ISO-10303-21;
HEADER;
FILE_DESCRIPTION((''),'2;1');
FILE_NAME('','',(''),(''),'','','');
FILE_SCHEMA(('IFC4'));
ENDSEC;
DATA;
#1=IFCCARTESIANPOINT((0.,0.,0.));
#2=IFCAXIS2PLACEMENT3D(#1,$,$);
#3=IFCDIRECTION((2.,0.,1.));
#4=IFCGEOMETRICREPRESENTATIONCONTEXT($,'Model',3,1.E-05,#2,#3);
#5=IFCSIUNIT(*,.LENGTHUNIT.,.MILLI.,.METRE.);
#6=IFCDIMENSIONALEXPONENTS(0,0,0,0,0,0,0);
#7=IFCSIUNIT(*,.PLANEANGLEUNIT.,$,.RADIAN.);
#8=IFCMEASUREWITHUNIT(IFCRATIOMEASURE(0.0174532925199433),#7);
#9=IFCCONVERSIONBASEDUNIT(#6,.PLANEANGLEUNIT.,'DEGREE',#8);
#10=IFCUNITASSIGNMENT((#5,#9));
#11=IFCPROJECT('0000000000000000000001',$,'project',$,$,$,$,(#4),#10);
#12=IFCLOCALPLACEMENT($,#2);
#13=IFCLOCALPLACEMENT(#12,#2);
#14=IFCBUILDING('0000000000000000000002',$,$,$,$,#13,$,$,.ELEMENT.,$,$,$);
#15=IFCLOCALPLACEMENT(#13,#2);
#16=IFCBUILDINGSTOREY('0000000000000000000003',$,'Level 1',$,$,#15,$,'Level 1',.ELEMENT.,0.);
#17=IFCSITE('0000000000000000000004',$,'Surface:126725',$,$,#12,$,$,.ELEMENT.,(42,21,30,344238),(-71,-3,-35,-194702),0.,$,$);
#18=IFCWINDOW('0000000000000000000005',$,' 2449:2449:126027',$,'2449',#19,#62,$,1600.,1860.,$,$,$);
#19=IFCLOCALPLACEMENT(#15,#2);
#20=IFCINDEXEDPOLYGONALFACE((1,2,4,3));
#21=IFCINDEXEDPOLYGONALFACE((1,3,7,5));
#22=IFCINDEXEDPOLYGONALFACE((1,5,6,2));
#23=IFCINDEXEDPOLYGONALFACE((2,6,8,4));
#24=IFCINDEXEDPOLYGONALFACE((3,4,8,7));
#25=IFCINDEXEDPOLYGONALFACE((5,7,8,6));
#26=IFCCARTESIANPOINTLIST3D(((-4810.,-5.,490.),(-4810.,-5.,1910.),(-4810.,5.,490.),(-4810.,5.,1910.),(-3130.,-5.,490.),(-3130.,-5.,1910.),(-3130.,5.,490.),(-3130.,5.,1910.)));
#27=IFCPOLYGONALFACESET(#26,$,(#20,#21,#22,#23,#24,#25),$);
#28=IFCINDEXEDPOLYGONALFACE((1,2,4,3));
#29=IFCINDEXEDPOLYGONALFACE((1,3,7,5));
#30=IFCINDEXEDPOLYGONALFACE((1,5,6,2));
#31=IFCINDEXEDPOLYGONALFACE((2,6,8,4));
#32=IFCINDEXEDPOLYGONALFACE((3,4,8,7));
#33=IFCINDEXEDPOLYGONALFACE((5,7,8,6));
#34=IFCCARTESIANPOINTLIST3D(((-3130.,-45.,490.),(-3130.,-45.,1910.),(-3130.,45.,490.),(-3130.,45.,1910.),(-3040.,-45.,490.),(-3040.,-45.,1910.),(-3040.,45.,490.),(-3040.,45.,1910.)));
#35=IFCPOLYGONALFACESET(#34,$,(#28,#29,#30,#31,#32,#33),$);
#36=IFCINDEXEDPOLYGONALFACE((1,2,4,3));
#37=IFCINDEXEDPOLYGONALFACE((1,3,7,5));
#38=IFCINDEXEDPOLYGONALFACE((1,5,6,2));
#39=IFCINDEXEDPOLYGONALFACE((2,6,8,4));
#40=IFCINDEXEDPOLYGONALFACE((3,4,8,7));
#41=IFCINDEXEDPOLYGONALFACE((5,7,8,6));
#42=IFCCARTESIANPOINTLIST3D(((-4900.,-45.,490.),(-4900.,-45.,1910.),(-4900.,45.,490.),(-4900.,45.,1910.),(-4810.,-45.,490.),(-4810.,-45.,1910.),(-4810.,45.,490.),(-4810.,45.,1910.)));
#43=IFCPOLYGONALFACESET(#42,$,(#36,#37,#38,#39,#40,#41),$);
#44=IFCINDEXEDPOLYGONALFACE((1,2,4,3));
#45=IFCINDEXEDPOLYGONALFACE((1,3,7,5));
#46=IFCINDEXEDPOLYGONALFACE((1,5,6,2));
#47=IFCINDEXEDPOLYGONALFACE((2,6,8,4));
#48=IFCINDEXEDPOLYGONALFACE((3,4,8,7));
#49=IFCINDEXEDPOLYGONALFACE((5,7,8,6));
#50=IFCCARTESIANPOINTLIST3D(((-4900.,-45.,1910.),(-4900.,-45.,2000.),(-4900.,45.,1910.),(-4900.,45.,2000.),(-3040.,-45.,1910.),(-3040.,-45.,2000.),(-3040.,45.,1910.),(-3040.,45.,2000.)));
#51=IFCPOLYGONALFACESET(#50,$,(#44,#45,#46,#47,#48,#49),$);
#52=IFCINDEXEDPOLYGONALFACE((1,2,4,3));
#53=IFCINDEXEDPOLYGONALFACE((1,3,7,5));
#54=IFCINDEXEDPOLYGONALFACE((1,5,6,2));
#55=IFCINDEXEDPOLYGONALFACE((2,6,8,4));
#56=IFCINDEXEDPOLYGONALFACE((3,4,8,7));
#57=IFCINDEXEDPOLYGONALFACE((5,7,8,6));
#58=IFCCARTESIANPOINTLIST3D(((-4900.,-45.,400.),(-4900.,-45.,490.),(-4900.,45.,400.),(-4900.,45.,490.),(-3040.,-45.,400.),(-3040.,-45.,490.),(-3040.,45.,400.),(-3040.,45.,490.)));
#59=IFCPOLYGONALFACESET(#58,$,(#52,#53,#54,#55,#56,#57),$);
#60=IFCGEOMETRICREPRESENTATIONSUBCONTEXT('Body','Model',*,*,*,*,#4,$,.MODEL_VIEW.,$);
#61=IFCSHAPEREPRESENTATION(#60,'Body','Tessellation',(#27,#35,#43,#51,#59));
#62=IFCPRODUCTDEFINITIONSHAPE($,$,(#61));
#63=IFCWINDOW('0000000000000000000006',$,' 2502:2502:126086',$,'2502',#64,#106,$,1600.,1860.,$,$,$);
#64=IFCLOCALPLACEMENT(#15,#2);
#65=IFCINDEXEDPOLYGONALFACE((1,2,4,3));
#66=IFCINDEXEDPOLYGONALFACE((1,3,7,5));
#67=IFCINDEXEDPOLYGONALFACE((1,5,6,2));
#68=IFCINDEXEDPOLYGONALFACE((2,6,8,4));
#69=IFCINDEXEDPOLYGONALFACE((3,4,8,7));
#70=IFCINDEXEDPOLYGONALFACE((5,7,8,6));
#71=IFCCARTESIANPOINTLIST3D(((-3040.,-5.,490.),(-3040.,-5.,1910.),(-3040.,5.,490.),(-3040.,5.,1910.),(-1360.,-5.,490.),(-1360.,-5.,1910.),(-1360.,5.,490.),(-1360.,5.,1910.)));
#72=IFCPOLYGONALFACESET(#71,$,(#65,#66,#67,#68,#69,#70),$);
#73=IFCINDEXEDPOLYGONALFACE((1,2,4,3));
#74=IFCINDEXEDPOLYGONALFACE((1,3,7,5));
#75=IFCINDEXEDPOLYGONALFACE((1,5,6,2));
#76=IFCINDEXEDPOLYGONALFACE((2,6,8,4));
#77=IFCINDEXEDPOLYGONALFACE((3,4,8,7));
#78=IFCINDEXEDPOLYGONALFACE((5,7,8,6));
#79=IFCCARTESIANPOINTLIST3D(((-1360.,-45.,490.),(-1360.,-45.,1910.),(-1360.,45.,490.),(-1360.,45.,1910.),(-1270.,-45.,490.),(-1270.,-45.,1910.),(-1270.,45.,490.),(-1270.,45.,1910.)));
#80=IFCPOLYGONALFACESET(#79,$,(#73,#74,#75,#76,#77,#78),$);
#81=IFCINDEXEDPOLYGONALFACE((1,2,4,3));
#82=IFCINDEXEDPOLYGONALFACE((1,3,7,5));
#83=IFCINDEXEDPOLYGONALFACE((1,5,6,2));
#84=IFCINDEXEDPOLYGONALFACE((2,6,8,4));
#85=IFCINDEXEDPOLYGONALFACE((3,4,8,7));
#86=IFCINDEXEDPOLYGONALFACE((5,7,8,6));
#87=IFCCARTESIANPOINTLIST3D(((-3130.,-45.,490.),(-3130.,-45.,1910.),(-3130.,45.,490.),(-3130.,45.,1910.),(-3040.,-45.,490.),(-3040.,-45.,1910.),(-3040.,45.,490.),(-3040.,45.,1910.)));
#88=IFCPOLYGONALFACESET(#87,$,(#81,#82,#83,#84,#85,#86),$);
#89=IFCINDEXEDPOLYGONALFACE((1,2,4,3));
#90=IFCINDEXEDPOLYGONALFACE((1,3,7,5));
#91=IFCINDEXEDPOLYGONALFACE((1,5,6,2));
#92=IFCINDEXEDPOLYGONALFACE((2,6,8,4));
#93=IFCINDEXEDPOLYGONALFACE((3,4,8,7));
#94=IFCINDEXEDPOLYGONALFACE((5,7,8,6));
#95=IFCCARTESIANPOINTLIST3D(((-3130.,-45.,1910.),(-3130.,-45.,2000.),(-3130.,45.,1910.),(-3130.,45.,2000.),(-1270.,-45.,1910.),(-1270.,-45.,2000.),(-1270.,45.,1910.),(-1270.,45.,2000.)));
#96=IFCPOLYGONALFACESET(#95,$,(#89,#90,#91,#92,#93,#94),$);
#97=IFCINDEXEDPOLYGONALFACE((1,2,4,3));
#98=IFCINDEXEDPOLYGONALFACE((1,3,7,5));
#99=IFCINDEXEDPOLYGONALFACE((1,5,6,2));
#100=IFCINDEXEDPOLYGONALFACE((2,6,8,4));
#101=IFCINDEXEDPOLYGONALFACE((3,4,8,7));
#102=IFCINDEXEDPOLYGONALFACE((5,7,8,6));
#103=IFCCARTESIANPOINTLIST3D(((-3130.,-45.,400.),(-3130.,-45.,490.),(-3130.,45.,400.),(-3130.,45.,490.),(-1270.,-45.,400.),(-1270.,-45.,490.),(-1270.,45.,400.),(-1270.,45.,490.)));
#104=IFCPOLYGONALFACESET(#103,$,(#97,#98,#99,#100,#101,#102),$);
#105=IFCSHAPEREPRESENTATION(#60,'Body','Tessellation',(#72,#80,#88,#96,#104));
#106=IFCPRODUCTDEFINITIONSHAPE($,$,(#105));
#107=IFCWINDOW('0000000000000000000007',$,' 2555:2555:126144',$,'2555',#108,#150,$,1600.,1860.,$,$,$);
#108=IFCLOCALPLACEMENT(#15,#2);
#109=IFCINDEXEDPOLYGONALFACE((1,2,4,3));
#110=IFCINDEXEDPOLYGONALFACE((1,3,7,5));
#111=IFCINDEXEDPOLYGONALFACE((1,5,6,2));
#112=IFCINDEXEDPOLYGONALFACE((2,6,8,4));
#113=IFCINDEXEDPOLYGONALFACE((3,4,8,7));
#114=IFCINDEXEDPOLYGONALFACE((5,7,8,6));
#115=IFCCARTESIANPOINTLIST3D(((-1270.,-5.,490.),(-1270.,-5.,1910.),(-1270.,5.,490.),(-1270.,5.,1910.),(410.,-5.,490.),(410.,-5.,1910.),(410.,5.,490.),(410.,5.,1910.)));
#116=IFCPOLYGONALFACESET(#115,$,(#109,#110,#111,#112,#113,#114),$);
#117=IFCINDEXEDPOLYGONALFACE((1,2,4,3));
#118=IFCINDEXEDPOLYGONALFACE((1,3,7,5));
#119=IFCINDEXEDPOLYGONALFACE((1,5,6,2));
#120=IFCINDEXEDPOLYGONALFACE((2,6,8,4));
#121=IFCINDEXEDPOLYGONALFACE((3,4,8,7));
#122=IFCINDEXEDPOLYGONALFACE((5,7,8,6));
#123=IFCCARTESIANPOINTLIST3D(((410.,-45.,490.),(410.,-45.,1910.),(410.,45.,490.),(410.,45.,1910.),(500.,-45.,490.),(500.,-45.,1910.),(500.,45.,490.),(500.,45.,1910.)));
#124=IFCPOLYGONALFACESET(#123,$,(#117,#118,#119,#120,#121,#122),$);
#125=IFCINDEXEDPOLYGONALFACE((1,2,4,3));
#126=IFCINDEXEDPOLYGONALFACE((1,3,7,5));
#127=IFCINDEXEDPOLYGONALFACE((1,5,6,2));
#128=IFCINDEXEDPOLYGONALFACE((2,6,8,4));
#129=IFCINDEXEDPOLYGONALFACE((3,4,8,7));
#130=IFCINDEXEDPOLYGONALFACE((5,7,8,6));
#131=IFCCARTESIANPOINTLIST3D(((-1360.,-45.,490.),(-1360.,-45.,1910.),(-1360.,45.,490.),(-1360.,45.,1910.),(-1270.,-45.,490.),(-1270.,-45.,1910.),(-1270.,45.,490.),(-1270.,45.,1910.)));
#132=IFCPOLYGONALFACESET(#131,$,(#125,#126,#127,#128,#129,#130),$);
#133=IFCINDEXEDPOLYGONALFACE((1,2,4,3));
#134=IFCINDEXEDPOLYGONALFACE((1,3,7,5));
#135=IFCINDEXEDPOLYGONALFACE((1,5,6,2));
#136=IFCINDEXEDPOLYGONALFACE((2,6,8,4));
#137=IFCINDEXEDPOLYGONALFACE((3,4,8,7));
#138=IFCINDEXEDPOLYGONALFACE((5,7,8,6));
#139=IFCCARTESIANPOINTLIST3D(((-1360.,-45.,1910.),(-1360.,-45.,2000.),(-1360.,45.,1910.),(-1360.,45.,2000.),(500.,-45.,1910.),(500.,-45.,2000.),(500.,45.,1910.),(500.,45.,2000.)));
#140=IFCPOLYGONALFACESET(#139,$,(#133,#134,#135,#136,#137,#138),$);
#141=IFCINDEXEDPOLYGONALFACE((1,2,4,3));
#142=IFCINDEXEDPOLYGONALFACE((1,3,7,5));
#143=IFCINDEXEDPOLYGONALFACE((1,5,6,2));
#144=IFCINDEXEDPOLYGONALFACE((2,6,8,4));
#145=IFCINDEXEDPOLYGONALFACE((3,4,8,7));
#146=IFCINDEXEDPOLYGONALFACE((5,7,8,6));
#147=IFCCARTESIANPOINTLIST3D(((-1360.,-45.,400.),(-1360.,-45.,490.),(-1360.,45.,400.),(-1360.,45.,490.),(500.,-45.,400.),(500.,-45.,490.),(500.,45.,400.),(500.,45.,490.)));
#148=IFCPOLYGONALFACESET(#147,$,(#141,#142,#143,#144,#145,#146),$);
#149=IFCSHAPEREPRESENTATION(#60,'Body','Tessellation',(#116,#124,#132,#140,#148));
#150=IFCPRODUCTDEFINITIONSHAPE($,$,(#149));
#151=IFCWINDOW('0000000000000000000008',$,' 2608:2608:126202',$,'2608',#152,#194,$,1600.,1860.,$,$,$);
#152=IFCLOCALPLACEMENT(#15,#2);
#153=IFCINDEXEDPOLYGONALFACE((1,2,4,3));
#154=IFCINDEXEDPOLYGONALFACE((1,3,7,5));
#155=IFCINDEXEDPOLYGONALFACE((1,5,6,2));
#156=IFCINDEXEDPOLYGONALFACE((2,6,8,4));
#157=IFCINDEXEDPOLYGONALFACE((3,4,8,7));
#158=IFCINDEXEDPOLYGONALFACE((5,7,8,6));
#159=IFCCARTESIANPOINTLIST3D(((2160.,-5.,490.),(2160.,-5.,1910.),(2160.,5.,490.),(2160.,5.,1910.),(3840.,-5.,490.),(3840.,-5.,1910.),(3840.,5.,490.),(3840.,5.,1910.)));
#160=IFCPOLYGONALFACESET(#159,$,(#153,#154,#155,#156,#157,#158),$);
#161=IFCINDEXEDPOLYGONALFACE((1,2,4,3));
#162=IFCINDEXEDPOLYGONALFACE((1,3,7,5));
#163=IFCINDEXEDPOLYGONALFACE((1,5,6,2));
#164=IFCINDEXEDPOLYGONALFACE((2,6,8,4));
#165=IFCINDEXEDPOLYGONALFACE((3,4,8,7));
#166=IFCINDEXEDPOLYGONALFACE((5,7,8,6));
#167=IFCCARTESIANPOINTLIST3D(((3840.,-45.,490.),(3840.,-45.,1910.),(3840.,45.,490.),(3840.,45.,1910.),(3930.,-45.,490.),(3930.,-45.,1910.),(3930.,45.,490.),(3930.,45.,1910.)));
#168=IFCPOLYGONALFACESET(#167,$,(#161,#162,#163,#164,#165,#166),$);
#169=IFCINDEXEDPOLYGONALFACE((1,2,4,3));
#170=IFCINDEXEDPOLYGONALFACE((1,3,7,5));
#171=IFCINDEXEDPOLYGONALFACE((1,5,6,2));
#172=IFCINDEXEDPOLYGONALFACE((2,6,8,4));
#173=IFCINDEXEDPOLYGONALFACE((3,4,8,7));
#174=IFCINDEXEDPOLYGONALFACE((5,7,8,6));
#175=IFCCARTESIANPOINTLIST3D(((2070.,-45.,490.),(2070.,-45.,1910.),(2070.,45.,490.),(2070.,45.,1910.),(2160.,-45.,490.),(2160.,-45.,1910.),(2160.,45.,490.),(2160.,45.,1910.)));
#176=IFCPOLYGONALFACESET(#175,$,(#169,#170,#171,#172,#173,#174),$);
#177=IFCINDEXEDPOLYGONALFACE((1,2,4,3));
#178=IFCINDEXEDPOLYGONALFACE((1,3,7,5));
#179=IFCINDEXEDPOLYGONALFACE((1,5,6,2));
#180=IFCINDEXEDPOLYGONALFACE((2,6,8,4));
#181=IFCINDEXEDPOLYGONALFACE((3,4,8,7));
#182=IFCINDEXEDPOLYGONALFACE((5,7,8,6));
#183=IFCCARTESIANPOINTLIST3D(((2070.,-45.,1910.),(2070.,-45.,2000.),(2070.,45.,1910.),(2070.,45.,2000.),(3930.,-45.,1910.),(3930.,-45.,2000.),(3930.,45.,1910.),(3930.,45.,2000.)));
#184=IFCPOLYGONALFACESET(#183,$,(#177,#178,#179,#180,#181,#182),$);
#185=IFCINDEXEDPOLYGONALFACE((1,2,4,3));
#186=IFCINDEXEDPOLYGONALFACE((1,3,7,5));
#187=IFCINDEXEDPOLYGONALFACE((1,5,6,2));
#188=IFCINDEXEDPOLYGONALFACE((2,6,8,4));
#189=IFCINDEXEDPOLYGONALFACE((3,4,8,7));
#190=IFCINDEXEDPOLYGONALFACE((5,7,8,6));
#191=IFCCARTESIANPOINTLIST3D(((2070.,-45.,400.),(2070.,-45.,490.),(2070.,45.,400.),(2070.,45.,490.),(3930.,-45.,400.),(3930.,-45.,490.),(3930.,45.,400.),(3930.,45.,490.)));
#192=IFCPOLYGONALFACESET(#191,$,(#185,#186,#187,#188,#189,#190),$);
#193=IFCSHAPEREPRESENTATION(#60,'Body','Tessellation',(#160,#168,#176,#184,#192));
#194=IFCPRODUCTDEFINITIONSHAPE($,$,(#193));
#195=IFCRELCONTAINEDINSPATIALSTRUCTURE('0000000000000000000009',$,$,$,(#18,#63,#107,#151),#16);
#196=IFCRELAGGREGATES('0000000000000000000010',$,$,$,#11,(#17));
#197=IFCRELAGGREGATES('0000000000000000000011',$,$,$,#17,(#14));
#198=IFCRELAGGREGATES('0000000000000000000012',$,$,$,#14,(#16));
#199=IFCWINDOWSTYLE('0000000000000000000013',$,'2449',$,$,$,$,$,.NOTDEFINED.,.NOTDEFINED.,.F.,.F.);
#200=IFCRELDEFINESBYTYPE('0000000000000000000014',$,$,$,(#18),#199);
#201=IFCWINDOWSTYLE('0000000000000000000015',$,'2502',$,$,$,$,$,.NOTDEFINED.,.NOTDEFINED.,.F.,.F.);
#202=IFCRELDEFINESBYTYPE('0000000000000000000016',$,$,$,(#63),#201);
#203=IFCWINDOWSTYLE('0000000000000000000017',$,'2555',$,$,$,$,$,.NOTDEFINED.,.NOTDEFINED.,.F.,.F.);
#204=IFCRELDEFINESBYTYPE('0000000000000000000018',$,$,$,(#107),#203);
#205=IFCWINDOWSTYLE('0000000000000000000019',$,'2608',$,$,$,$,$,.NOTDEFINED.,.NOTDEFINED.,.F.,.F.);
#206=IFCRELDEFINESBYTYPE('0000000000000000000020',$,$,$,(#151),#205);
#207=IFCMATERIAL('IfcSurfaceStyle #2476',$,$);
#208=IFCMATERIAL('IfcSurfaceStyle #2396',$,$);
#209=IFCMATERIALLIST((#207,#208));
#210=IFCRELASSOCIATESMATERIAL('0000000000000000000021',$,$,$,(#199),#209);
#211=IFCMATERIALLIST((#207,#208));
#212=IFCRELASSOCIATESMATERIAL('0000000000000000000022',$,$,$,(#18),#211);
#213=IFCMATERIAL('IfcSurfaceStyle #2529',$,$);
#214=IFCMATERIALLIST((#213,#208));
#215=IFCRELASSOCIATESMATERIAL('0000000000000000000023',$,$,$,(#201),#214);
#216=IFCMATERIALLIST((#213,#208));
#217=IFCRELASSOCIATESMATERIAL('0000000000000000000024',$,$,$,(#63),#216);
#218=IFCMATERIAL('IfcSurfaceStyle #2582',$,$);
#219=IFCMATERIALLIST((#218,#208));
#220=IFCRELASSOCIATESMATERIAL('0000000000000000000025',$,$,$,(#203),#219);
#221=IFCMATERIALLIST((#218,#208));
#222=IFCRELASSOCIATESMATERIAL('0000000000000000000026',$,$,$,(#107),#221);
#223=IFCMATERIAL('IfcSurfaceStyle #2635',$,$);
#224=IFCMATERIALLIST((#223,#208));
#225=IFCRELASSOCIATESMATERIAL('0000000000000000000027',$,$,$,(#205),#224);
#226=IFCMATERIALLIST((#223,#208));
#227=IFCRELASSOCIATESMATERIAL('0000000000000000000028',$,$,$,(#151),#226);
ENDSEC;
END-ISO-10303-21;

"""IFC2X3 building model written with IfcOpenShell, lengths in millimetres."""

from ifc_helpers import new_model, entity, si_unit, converted_unit, direction, frame, frame_2d, origin, origin_2d_with_axis, place, context, subcontext, project, spatial, rectangle, extrude, source, transform, mapped, material, material_list, type_object, type_shapes, element, save


model = new_model("IFC2X3")

# Units and contexts
model_context = context("Model", 3, precision=1e-05, world=origin(), true_north=direction((2.0, 0.0, 1.0)))
body_context = subcontext(model_context, "Body", "Model", "MODEL_VIEW")
ifc_project = project(units=[si_unit("LENGTHUNIT", "METRE", prefix="MILLI"), converted_unit("PLANEANGLEUNIT", "DEGREE", entity("IfcRatioMeasure", 0.0174532925199433), si_unit("PLANEANGLEUNIT", "RADIAN"), dimensions=[0, 0, 0, 0, 0, 0, 0])], contexts=[model_context])

# Site, building, storey
site_placement = place(None, origin())
site = spatial("IfcSite", under=ifc_project, at=site_placement, Name="Surface:126725", CompositionType="ELEMENT", RefLatitude=(42, 21, 30, 344238), RefLongitude=(-71, -3, -35, -194702), RefElevation=0.0)
building_placement = place(site_placement, origin())
building = spatial("IfcBuilding", under=site, at=building_placement, CompositionType="ELEMENT")
storey_placement = place(building_placement, origin())
storey = spatial("IfcBuildingStorey", under=building, at=storey_placement, Name="Level 1", LongName="Level 1", CompositionType="ELEMENT", Elevation=0.0)

# Windows
ifc_material_1 = material(Name="IfcSurfaceStyle #2476")
ifc_material_2 = material(Name="IfcSurfaceStyle #2396")
ifc_material_list_1 = material_list([ifc_material_1, ifc_material_2])
ifc_material_list_2 = material_list([ifc_material_1, ifc_material_2])
window_style_1 = type_object("IfcWindowStyle", Name="2449", ConstructionType="NOTDEFINED", OperationType="NOTDEFINED", ParameterTakesPrecedence=False, Sizeable=False, material=ifc_material_list_2)
shared_shape_1 = source(origin(), body_context, "Body", "SweptSolid", [
    extrude(rectangle(XDim=10.0, YDim=1680.0, at=origin_2d_with_axis()), frame((-3970.0, 0.0, 490.0), z_axis=(0.0, 0.0, 1.0), x_axis=(0.0, 1.0, 0.0)), (0.0, 0.0, 1.0), 1420.0),
    extrude(rectangle(XDim=90.0, YDim=90.0, at=frame_2d((0.0, 0.0), x_axis=(1.0, 0.0))), frame((-3085.0, 0.0, 490.0), z_axis=(0.0, 0.0, 1.0), x_axis=(0.0, 1.0, 0.0)), (0.0, 0.0, 1.0), 1420.0),
    extrude(rectangle(XDim=90.0, YDim=90.0, at=frame_2d((0.0, 0.0), x_axis=(1.0, 0.0))), frame((-4855.0, 0.0, 490.0), z_axis=(0.0, 0.0, 1.0), x_axis=(0.0, 1.0, 0.0)), (0.0, 0.0, 1.0), 1420.0),
    extrude(rectangle(XDim=90.0, YDim=1860.0, at=frame_2d((0.0, 0.0), x_axis=(1.0, 0.0))), frame((-3970.0, 0.0, 1910.0), z_axis=(0.0, 0.0, 1.0), x_axis=(0.0, 1.0, 0.0)), (0.0, 0.0, 1.0), 90.0),
    extrude(rectangle(XDim=90.0, YDim=1860.0, at=frame_2d((0.0, 0.0), x_axis=(1.0, 0.0))), frame((-3970.0, 0.0, 400.0), z_axis=(0.0, 0.0, 1.0), x_axis=(0.0, 1.0, 0.0)), (0.0, 0.0, 1.0), 90.0),
])
type_shapes(window_style_1, [shared_shape_1])
window_1_placement = place(storey_placement, origin())
element("IfcWindow", 1, at=window_1_placement, inside=storey, type_object=window_style_1, material=ifc_material_list_1, Name=" 2449:2449:126027", ObjectType="2449", OverallHeight=1600.0, OverallWidth=1860.0, context=body_context, shape_type="MappedRepresentation", body=[
    mapped(shared_shape_1, transform((0.0, 0.0, 0.0), scale=1.0)),
])
ifc_material_3 = material(Name="IfcSurfaceStyle #2529")
ifc_material_list_3 = material_list([ifc_material_3, ifc_material_2])
ifc_material_list_4 = material_list([ifc_material_3, ifc_material_2])
window_style_2 = type_object("IfcWindowStyle", Name="2502", ConstructionType="NOTDEFINED", OperationType="NOTDEFINED", ParameterTakesPrecedence=False, Sizeable=False, material=ifc_material_list_4)
shared_shape_2 = source(origin(), body_context, "Body", "SweptSolid", [
    extrude(rectangle(XDim=10.0, YDim=1680.0, at=origin_2d_with_axis()), frame((-2200.0, 0.0, 490.0), z_axis=(0.0, 0.0, 1.0), x_axis=(0.0, 1.0, 0.0)), (0.0, 0.0, 1.0), 1420.0),
    extrude(rectangle(XDim=90.0, YDim=90.0, at=frame_2d((0.0, 0.0), x_axis=(1.0, 0.0))), frame((-1315.0, 0.0, 490.0), z_axis=(0.0, 0.0, 1.0), x_axis=(0.0, 1.0, 0.0)), (0.0, 0.0, 1.0), 1420.0),
    extrude(rectangle(XDim=90.0, YDim=90.0, at=frame_2d((0.0, 0.0), x_axis=(1.0, 0.0))), frame((-3085.0, 0.0, 490.0), z_axis=(0.0, 0.0, 1.0), x_axis=(0.0, 1.0, 0.0)), (0.0, 0.0, 1.0), 1420.0),
    extrude(rectangle(XDim=90.0, YDim=1860.0, at=frame_2d((0.0, 0.0), x_axis=(1.0, 0.0))), frame((-2200.0, 0.0, 1910.0), z_axis=(0.0, 0.0, 1.0), x_axis=(0.0, 1.0, 0.0)), (0.0, 0.0, 1.0), 90.0),
    extrude(rectangle(XDim=90.0, YDim=1860.0, at=frame_2d((0.0, 0.0), x_axis=(1.0, 0.0))), frame((-2200.0, 0.0, 400.0), z_axis=(0.0, 0.0, 1.0), x_axis=(0.0, 1.0, 0.0)), (0.0, 0.0, 1.0), 90.0),
])
type_shapes(window_style_2, [shared_shape_2])
window_2_placement = place(storey_placement, origin())
element("IfcWindow", 2, at=window_2_placement, inside=storey, type_object=window_style_2, material=ifc_material_list_3, Name=" 2502:2502:126086", ObjectType="2502", OverallHeight=1600.0, OverallWidth=1860.0, context=body_context, shape_type="MappedRepresentation", body=[
    mapped(shared_shape_2, transform((0.0, 0.0, 0.0), scale=1.0)),
])
ifc_material_4 = material(Name="IfcSurfaceStyle #2582")
ifc_material_list_5 = material_list([ifc_material_4, ifc_material_2])
ifc_material_list_6 = material_list([ifc_material_4, ifc_material_2])
window_style_3 = type_object("IfcWindowStyle", Name="2555", ConstructionType="NOTDEFINED", OperationType="NOTDEFINED", ParameterTakesPrecedence=False, Sizeable=False, material=ifc_material_list_6)
shared_shape_3 = source(origin(), body_context, "Body", "SweptSolid", [
    extrude(rectangle(XDim=10.0, YDim=1680.0, at=origin_2d_with_axis()), frame((-430.0, 0.0, 490.0), z_axis=(0.0, 0.0, 1.0), x_axis=(0.0, 1.0, 0.0)), (0.0, 0.0, 1.0), 1420.0),
    extrude(rectangle(XDim=90.0, YDim=90.0, at=frame_2d((0.0, 0.0), x_axis=(1.0, 0.0))), frame((455.0, 0.0, 490.0), z_axis=(0.0, 0.0, 1.0), x_axis=(0.0, 1.0, 0.0)), (0.0, 0.0, 1.0), 1420.0),
    extrude(rectangle(XDim=90.0, YDim=90.0, at=frame_2d((0.0, 0.0), x_axis=(1.0, 0.0))), frame((-1315.0, 0.0, 490.0), z_axis=(0.0, 0.0, 1.0), x_axis=(0.0, 1.0, 0.0)), (0.0, 0.0, 1.0), 1420.0),
    extrude(rectangle(XDim=90.0, YDim=1860.0, at=origin_2d_with_axis()), frame((-430.0, 0.0, 1910.0), z_axis=(0.0, 0.0, 1.0), x_axis=(0.0, 1.0, 0.0)), (0.0, 0.0, 1.0), 90.0),
    extrude(rectangle(XDim=90.0, YDim=1860.0, at=origin_2d_with_axis()), frame((-430.0, 0.0, 400.0), z_axis=(0.0, 0.0, 1.0), x_axis=(0.0, 1.0, 0.0)), (0.0, 0.0, 1.0), 90.0),
])
type_shapes(window_style_3, [shared_shape_3])
window_3_placement = place(storey_placement, origin())
element("IfcWindow", 3, at=window_3_placement, inside=storey, type_object=window_style_3, material=ifc_material_list_5, Name=" 2555:2555:126144", ObjectType="2555", OverallHeight=1600.0, OverallWidth=1860.0, context=body_context, shape_type="MappedRepresentation", body=[
    mapped(shared_shape_3, transform((0.0, 0.0, 0.0), scale=1.0)),
])
ifc_material_5 = material(Name="IfcSurfaceStyle #2635")
ifc_material_list_7 = material_list([ifc_material_5, ifc_material_2])
ifc_material_list_8 = material_list([ifc_material_5, ifc_material_2])
window_style_4 = type_object("IfcWindowStyle", Name="2608", ConstructionType="NOTDEFINED", OperationType="NOTDEFINED", ParameterTakesPrecedence=False, Sizeable=False, material=ifc_material_list_8)
shared_shape_4 = source(origin(), body_context, "Body", "SweptSolid", [
    extrude(rectangle(XDim=10.0, YDim=1680.0, at=frame_2d((0.0, 0.0), x_axis=(1.0, 0.0))), frame((3000.0, 0.0, 490.0), z_axis=(0.0, 0.0, 1.0), x_axis=(0.0, 1.0, 0.0)), (0.0, 0.0, 1.0), 1420.0),
    extrude(rectangle(XDim=90.0, YDim=90.0, at=origin_2d_with_axis()), frame((3885.0, 0.0, 490.0), z_axis=(0.0, 0.0, 1.0), x_axis=(0.0, 1.0, 0.0)), (0.0, 0.0, 1.0), 1420.0),
    extrude(rectangle(XDim=90.0, YDim=90.0, at=origin_2d_with_axis()), frame((2115.0, 0.0, 490.0), z_axis=(0.0, 0.0, 1.0), x_axis=(0.0, 1.0, 0.0)), (0.0, 0.0, 1.0), 1420.0),
    extrude(rectangle(XDim=90.0, YDim=1860.0, at=frame_2d((0.0, 0.0), x_axis=(1.0, 0.0))), frame((3000.0, 0.0, 1910.0), z_axis=(0.0, 0.0, 1.0), x_axis=(0.0, 1.0, 0.0)), (0.0, 0.0, 1.0), 90.0),
    extrude(rectangle(XDim=90.0, YDim=1860.0, at=frame_2d((0.0, 0.0), x_axis=(1.0, 0.0))), frame((3000.0, 0.0, 400.0), z_axis=(0.0, 0.0, 1.0), x_axis=(0.0, 1.0, 0.0)), (0.0, 0.0, 1.0), 90.0),
])
type_shapes(window_style_4, [shared_shape_4])
window_4_placement = place(storey_placement, origin())
element("IfcWindow", 4, at=window_4_placement, inside=storey, type_object=window_style_4, material=ifc_material_list_7, Name=" 2608:2608:126202", ObjectType="2608", OverallHeight=1600.0, OverallWidth=1860.0, context=body_context, shape_type="MappedRepresentation", body=[
    mapped(shared_shape_4, transform((0.0, 0.0, 0.0), scale=1.0)),
])

save(model, "model.ifc")
